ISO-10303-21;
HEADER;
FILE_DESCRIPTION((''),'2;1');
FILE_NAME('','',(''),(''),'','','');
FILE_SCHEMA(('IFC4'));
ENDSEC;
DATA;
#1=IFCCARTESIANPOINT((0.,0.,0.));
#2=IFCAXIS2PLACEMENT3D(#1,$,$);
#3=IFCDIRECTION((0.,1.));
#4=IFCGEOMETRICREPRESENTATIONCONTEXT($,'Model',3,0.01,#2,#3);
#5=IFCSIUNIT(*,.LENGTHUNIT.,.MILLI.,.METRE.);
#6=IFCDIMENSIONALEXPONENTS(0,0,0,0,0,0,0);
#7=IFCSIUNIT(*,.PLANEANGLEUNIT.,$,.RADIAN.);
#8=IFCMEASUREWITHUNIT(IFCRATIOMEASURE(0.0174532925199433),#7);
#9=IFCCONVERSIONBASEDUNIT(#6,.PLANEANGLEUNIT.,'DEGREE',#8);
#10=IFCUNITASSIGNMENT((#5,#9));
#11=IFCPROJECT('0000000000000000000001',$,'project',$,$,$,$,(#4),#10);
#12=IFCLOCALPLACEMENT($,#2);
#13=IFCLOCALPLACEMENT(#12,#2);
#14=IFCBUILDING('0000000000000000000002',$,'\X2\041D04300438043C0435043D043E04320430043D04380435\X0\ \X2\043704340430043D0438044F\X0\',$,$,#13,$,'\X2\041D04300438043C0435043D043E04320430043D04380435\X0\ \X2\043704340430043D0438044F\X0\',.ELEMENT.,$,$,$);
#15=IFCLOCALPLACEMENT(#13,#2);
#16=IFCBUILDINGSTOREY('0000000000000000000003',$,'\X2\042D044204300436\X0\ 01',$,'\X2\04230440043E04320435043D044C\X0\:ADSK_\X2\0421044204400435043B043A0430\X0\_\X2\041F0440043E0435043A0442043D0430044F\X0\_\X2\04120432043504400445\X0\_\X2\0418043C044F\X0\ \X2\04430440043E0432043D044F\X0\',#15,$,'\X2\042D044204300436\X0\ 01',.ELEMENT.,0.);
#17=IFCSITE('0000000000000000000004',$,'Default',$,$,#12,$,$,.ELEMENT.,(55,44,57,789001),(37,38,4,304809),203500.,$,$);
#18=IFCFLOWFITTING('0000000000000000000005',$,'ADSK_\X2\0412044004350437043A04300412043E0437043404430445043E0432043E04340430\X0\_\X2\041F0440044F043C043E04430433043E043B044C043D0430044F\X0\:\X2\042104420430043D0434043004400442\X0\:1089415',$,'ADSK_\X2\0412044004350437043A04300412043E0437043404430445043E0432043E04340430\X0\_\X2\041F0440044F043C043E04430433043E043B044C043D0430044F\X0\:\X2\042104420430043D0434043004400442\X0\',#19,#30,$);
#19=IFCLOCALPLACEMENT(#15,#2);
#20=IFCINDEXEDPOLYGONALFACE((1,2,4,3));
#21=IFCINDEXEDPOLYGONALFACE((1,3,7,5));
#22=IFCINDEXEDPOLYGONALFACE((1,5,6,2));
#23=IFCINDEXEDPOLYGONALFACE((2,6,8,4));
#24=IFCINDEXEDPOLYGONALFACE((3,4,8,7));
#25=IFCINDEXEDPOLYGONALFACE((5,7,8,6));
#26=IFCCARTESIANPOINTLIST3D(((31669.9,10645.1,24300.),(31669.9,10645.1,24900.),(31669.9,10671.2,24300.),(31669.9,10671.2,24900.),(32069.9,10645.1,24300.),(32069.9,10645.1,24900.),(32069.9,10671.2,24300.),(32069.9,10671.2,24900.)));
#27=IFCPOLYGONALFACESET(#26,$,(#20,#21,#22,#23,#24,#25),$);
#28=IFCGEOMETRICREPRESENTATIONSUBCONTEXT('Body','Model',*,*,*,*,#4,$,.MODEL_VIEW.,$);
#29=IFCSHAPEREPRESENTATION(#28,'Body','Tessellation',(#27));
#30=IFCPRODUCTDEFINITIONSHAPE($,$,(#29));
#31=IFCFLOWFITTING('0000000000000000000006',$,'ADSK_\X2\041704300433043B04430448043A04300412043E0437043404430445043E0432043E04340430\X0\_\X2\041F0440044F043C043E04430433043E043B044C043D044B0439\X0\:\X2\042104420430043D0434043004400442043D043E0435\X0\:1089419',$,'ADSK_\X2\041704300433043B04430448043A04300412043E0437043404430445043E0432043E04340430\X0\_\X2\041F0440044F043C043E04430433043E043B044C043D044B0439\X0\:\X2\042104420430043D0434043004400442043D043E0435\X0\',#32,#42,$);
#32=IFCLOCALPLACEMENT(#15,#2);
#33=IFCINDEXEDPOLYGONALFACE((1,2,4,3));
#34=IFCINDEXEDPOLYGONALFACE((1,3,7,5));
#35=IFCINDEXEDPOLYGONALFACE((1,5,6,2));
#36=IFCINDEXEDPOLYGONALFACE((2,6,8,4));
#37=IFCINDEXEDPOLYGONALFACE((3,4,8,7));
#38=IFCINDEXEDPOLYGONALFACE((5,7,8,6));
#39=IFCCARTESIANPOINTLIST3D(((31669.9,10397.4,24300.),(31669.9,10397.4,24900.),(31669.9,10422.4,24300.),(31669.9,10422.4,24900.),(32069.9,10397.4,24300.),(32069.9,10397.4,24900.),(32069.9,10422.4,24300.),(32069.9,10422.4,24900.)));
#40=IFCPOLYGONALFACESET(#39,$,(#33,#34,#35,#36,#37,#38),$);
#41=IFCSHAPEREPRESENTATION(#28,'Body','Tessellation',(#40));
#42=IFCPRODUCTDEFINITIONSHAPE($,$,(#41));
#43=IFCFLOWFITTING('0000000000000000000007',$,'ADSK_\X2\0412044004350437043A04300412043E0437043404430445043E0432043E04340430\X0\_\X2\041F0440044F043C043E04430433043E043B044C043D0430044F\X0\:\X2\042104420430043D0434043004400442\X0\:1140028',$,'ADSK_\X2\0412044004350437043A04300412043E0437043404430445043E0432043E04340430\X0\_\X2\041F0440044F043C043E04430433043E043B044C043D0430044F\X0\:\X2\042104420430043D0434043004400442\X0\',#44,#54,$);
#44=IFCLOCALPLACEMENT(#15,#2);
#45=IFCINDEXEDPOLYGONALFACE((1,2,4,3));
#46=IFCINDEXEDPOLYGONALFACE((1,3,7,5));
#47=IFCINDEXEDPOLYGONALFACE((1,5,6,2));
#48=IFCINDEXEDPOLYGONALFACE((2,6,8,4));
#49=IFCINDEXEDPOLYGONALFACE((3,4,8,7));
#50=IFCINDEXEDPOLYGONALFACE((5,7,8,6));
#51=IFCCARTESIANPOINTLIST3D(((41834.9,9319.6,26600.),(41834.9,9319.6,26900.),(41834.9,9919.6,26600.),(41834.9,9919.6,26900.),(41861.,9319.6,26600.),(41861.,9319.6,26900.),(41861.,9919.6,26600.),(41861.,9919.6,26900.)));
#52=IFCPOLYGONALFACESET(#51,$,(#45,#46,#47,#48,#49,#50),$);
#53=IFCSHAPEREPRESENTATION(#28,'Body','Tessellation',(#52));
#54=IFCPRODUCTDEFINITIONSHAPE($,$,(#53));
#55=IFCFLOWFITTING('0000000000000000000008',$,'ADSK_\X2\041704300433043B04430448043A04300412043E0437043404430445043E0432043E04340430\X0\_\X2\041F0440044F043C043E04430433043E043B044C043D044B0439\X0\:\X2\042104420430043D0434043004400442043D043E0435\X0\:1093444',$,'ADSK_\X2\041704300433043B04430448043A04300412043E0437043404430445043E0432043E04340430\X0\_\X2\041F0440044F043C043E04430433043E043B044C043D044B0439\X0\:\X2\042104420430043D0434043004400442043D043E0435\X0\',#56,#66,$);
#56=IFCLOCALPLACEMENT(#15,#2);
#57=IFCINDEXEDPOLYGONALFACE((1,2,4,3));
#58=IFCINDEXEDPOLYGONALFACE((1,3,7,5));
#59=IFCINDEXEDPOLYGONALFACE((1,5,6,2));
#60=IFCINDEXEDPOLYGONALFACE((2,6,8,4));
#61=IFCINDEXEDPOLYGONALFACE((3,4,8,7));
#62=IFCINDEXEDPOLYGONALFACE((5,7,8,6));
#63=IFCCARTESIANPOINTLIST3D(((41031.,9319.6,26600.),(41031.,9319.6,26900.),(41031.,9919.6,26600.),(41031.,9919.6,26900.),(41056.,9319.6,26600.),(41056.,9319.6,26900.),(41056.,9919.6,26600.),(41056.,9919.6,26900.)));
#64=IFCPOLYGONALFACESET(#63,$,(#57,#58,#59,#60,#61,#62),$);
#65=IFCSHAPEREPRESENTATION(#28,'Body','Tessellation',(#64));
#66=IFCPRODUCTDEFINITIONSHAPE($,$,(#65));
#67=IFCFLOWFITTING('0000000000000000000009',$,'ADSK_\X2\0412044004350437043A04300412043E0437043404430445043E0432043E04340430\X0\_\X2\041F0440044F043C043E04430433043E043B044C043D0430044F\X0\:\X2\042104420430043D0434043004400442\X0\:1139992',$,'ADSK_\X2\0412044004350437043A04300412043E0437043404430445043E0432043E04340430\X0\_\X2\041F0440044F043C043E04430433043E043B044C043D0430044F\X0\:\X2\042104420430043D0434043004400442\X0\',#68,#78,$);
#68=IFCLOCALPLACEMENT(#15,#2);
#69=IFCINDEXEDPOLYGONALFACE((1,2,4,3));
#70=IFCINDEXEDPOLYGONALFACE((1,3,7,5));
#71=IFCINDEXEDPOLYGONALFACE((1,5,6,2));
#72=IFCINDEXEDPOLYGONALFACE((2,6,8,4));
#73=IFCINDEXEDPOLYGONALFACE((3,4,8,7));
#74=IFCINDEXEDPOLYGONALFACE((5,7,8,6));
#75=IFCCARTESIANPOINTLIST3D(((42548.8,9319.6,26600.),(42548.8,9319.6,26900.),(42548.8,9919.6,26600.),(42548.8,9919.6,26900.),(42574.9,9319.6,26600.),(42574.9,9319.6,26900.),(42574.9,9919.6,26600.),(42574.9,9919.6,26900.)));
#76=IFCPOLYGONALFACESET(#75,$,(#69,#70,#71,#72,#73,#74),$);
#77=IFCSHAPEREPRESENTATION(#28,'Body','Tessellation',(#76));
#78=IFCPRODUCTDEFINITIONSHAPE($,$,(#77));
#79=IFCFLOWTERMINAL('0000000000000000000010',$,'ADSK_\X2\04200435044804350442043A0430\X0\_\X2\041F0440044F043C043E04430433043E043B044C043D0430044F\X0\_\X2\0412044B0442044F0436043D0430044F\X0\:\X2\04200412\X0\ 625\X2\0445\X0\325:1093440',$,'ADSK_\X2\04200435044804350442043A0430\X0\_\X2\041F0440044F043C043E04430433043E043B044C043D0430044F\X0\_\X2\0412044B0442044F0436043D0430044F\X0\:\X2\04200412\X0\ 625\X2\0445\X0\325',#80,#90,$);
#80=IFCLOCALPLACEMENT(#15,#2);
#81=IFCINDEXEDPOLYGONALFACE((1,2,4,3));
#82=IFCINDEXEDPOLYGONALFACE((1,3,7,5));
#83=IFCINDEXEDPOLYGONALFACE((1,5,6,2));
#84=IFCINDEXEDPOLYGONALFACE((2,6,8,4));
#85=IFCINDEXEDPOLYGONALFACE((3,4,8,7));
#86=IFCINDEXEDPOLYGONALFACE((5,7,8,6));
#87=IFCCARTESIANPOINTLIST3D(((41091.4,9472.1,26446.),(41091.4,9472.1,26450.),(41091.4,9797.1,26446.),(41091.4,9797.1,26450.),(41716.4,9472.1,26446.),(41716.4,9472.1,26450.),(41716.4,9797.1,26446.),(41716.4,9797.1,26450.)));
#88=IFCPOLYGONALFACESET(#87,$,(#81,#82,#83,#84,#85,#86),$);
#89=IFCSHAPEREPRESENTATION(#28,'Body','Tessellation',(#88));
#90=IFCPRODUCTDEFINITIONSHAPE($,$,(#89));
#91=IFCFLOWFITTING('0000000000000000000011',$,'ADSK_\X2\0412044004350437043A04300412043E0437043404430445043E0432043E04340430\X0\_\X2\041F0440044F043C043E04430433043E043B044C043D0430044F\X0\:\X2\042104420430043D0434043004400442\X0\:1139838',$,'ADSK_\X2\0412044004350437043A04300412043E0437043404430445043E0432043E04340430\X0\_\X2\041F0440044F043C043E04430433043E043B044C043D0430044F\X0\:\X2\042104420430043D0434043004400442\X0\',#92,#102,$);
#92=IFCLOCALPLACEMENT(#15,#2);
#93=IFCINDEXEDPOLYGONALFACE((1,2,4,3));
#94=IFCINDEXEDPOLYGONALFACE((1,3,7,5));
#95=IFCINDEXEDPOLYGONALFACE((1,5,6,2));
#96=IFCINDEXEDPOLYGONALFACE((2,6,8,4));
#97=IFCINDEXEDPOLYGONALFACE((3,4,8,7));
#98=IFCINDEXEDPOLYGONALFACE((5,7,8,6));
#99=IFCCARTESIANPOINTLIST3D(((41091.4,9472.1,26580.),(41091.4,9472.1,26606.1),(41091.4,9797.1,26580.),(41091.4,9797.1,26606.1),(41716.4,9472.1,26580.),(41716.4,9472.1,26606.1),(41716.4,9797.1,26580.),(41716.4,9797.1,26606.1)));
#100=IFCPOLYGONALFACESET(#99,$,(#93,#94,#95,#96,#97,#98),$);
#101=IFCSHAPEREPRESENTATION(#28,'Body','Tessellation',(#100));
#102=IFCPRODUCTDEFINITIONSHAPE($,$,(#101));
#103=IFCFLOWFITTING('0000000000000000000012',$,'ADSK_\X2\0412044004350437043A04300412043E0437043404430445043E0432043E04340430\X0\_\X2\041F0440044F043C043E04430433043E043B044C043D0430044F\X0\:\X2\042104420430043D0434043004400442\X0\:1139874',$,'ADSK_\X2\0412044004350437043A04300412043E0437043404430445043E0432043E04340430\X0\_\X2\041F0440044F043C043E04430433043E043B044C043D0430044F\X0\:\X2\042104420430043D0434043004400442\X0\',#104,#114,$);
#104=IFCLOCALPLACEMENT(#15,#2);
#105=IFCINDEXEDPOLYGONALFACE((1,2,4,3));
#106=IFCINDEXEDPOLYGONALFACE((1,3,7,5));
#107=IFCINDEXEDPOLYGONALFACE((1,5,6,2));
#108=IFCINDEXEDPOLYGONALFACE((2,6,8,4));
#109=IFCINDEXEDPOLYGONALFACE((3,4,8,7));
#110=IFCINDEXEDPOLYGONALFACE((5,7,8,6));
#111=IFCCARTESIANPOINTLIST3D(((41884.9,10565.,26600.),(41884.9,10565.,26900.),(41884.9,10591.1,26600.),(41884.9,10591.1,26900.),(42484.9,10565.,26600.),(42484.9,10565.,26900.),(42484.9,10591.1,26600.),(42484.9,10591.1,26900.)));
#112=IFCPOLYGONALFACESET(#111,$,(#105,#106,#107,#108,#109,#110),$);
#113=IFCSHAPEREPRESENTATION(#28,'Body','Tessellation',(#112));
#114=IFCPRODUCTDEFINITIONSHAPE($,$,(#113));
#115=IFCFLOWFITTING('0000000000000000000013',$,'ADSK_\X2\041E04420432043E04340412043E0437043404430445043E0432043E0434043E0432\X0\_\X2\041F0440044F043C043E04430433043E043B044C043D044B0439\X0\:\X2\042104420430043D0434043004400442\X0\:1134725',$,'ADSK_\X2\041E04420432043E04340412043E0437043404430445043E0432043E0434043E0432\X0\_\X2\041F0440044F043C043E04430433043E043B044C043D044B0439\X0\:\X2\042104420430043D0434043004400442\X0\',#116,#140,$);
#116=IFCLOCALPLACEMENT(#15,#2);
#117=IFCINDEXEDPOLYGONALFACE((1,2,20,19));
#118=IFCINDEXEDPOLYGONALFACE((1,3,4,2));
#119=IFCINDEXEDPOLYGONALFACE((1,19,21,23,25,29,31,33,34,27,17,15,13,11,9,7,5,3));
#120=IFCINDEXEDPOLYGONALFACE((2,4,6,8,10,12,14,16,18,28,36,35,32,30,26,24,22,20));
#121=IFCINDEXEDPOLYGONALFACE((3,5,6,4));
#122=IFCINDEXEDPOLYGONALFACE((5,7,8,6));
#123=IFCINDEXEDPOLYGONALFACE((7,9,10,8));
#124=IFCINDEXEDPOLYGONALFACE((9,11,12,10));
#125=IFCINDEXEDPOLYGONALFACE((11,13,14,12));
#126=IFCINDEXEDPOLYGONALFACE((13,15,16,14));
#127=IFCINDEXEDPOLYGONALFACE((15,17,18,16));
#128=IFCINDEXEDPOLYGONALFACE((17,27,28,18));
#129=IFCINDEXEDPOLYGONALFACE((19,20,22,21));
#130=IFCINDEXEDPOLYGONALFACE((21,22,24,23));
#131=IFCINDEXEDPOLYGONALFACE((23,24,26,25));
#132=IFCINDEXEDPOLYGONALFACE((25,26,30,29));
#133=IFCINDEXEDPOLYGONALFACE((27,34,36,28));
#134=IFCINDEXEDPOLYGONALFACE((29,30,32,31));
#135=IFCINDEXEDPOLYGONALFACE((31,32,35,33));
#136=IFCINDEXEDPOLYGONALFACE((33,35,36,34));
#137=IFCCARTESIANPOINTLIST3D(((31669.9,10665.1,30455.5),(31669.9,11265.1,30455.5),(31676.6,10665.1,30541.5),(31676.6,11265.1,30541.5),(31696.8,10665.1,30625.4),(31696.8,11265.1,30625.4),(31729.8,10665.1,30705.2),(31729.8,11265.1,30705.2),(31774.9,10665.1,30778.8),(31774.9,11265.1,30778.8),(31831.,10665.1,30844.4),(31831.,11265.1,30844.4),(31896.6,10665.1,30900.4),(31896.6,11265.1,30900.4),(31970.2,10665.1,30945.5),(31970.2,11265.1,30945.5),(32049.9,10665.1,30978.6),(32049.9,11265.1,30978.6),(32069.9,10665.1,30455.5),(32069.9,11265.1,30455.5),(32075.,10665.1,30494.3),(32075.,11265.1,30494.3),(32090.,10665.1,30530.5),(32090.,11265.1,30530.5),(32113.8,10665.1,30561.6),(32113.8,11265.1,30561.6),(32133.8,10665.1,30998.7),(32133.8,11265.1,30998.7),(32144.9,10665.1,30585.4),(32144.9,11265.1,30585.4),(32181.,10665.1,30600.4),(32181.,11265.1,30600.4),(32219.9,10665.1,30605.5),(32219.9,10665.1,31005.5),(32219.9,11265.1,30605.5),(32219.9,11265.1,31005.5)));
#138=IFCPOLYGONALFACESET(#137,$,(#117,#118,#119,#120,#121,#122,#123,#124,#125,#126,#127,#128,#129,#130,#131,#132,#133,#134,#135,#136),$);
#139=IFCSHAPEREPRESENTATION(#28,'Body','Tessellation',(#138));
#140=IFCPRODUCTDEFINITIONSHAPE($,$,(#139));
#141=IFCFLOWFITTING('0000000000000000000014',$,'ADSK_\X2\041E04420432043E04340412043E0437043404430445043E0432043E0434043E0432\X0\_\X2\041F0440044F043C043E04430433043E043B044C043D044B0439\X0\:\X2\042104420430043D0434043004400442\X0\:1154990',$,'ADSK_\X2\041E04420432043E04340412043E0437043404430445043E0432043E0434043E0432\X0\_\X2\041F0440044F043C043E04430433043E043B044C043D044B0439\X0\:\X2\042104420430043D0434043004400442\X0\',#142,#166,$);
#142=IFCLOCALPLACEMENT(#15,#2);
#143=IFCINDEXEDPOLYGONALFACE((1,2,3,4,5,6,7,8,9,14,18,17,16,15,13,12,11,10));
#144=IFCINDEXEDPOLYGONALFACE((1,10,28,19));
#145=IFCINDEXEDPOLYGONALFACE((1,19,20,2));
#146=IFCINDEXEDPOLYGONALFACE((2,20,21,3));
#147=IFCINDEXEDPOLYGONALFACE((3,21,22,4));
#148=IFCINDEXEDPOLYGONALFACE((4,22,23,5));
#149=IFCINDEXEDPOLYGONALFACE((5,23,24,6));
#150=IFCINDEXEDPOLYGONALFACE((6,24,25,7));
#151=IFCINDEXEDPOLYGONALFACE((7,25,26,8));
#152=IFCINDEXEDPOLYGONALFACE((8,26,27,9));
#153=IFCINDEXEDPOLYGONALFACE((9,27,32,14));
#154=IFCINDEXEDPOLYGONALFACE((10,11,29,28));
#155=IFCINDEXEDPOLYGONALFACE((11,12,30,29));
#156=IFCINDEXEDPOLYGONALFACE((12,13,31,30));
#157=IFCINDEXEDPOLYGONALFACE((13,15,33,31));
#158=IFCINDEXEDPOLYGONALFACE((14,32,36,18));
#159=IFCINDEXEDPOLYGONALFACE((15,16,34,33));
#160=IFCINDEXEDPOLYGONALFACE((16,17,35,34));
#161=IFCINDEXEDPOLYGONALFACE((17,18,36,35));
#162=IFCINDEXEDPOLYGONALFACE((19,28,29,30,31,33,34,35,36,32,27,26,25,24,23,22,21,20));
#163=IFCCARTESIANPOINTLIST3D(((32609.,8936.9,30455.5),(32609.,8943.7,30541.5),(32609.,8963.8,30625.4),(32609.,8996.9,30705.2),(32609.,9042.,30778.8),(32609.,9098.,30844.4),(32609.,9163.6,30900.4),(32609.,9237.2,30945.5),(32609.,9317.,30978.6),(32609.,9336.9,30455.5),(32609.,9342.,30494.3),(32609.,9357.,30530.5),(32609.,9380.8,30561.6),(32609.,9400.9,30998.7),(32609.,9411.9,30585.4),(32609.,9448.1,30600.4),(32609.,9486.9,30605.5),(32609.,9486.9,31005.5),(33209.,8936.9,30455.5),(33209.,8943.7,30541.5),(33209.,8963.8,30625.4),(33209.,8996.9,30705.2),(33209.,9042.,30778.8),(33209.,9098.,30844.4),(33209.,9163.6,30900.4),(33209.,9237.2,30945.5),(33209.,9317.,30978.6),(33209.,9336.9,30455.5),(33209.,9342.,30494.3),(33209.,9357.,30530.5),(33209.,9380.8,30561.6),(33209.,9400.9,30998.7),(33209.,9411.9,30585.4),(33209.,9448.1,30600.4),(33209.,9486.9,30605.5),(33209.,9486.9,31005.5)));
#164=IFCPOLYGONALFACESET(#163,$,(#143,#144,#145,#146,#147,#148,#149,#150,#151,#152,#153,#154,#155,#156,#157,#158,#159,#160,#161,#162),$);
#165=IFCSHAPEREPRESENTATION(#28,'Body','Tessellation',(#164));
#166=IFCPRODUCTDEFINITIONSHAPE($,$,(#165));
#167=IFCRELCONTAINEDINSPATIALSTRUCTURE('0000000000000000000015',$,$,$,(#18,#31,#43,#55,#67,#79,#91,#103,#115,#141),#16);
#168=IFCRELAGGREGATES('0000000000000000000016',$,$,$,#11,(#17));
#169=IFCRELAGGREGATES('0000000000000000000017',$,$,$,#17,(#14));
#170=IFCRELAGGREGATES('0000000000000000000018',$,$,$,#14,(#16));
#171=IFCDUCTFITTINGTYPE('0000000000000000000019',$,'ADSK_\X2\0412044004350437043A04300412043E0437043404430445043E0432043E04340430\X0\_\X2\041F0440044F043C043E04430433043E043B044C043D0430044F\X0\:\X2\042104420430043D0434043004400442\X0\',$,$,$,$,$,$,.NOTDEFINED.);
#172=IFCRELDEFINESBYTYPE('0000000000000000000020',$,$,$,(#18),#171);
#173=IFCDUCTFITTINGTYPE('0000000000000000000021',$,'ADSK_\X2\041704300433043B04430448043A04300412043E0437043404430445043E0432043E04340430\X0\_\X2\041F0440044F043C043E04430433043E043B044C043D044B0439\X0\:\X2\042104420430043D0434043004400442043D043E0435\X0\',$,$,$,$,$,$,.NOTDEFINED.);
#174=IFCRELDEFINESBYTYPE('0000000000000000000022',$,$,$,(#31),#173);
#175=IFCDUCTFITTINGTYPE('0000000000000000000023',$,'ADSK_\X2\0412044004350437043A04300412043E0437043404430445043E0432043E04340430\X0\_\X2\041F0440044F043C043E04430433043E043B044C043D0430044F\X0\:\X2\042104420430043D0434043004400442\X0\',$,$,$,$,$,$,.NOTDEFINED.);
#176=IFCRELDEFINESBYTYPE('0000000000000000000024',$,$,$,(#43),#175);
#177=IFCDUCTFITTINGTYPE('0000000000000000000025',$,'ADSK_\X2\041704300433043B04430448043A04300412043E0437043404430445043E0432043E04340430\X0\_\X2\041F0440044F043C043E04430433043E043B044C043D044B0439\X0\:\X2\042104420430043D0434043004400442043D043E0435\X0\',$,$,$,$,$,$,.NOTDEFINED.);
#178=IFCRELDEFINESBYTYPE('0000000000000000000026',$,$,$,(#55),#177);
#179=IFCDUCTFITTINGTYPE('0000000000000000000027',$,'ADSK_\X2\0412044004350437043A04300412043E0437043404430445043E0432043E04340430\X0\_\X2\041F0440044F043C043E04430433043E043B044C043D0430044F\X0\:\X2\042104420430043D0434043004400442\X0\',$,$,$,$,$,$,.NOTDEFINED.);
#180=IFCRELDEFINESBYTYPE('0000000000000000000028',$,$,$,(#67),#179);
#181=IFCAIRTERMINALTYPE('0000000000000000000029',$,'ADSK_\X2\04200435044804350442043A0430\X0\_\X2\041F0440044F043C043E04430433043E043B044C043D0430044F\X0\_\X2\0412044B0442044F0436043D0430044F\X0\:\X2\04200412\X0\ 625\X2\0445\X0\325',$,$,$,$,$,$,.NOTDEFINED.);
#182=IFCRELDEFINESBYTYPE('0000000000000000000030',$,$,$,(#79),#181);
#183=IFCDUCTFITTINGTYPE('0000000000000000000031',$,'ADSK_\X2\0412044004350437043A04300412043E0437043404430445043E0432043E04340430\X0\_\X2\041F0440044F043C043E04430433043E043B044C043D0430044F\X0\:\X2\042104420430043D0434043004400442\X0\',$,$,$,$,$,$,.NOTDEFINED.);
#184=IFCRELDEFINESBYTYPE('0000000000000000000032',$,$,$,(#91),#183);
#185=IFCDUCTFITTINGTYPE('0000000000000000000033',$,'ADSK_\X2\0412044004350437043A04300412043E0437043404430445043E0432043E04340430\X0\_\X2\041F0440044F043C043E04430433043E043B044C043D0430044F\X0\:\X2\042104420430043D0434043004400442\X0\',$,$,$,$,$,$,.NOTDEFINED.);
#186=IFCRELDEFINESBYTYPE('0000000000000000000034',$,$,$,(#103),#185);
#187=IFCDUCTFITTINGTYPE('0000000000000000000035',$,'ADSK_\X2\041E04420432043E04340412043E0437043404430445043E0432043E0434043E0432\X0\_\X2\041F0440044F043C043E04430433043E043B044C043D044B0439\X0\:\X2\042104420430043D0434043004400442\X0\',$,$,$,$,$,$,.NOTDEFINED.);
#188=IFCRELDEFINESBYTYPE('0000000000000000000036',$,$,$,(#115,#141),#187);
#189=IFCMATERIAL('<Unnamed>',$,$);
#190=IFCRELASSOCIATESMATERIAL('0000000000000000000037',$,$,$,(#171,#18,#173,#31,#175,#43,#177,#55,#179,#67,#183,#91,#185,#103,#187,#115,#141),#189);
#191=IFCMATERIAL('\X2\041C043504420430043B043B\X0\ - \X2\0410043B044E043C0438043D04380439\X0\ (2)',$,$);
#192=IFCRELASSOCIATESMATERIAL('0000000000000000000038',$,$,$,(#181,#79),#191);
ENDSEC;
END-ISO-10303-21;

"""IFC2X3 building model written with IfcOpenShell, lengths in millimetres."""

from ifc_helpers import new_model, entity, si_unit, converted_unit, direction, frame, frame_2d, origin, origin_2d_with_axis, place, context, subcontext, project, spatial, polyline, circle_curve, parameter, trimmed, segment, composite_curve, rectangle, outline, extrude, source, transform, mapped, material, type_object, type_shapes, element, save


model = new_model("IFC2X3")

# Units and contexts
model_context = context("Model", 3, precision=0.01, world=origin(), true_north=direction((0.0, 1.0)))
body_context = subcontext(model_context, "Body", "Model", "MODEL_VIEW")
ifc_project = project(units=[si_unit("LENGTHUNIT", "METRE", prefix="MILLI"), converted_unit("PLANEANGLEUNIT", "DEGREE", entity("IfcRatioMeasure", 0.0174532925199433), si_unit("PLANEANGLEUNIT", "RADIAN"), dimensions=[0, 0, 0, 0, 0, 0, 0])], contexts=[model_context])

# Site, building, storey
site_placement = place(None, origin())
site = spatial("IfcSite", under=ifc_project, at=site_placement, Name="Default", CompositionType="ELEMENT", RefLatitude=(55, 44, 57, 789001), RefLongitude=(37, 38, 4, 304809), RefElevation=203500.0)
building_placement = place(site_placement, origin())
building = spatial("IfcBuilding", under=site, at=building_placement, Name="Наименование здания", LongName="Наименование здания", CompositionType="ELEMENT")
storey_placement = place(building_placement, origin())
storey = spatial("IfcBuildingStorey", under=building, at=storey_placement, Name="Этаж 01", ObjectType="Уровень:ADSK_Стрелка_Проектная_Вверх_Имя уровня", LongName="Этаж 01", CompositionType="ELEMENT", Elevation=0.0)

# Flow fittings
ifc_material_1 = material(Name="<Unnamed>")
duct_fitting_type_1 = type_object("IfcDuctFittingType", Name="ADSK_ВрезкаВоздуховода_Прямоугольная:Стандарт", PredefinedType="NOTDEFINED", material=ifc_material_1)
shared_shape_1 = source(origin(), body_context, "Body", "SweptSolid", [
    extrude(rectangle(XDim=26.1, YDim=600.0, at=origin_2d_with_axis()), frame((7.0, 0.0, -200.0)), (0.0, 0.0, 1.0), 400.0),
])
type_shapes(duct_fitting_type_1, [shared_shape_1])
flow_fitting_1_placement = place(storey_placement, frame((31869.9, 10665.1, 24600.0), z_axis=(-1.0, 0.0, 0.0), x_axis=(0.0, -1.0, 0.0)))
element("IfcFlowFitting", 1, at=flow_fitting_1_placement, inside=storey, type_object=duct_fitting_type_1, material=ifc_material_1, Name="ADSK_ВрезкаВоздуховода_Прямоугольная:Стандарт:1089415", ObjectType="ADSK_ВрезкаВоздуховода_Прямоугольная:Стандарт", context=body_context, shape_type="MappedRepresentation", body=[
    mapped(shared_shape_1, transform((0.0, 0.0, 0.0), scale=1.0)),
])
duct_fitting_type_2 = type_object("IfcDuctFittingType", Name="ADSK_ЗаглушкаВоздуховода_Прямоугольный:Стандартное", PredefinedType="NOTDEFINED", material=ifc_material_1)
shared_shape_2 = source(origin(), body_context, "Body", "SweptSolid", [
    extrude(rectangle(XDim=25.0, YDim=400.0, at=origin_2d_with_axis()), frame((12.5, 0.0, -300.0)), (0.0, 0.0, 1.0), 600.0),
])
type_shapes(duct_fitting_type_2, [shared_shape_2])
flow_fitting_2_placement = place(storey_placement, frame((31869.9, 10422.4, 24600.0), z_axis=(0.0, 0.0, 1.0), x_axis=(0.0, -1.0, 0.0)))
element("IfcFlowFitting", 2, at=flow_fitting_2_placement, inside=storey, type_object=duct_fitting_type_2, material=ifc_material_1, Name="ADSK_ЗаглушкаВоздуховода_Прямоугольный:Стандартное:1089419", ObjectType="ADSK_ЗаглушкаВоздуховода_Прямоугольный:Стандартное", context=body_context, shape_type="MappedRepresentation", body=[
    mapped(shared_shape_2, transform((0.0, 0.0, 0.0), scale=1.0)),
])
duct_fitting_type_3 = type_object("IfcDuctFittingType", Name="ADSK_ВрезкаВоздуховода_Прямоугольная:Стандарт", PredefinedType="NOTDEFINED", material=ifc_material_1)
shared_shape_3 = source(origin(), body_context, "Body", "SweptSolid", [
    extrude(rectangle(XDim=26.1, YDim=600.0, at=origin_2d_with_axis()), frame((7.0, 0.0, -150.0)), (0.0, 0.0, 1.0), 300.0),
])
type_shapes(duct_fitting_type_3, [shared_shape_3])
flow_fitting_3_placement = place(storey_placement, frame((41854.9, 9619.6, 26750.0), z_axis=(0.0, 0.0, -1.0), x_axis=(-1.0, 0.0, 0.0)))
element("IfcFlowFitting", 3, at=flow_fitting_3_placement, inside=storey, type_object=duct_fitting_type_3, material=ifc_material_1, Name="ADSK_ВрезкаВоздуховода_Прямоугольная:Стандарт:1140028", ObjectType="ADSK_ВрезкаВоздуховода_Прямоугольная:Стандарт", context=body_context, shape_type="MappedRepresentation", body=[
    mapped(shared_shape_3, transform((0.0, 0.0, 0.0), scale=1.0)),
])
duct_fitting_type_4 = type_object("IfcDuctFittingType", Name="ADSK_ЗаглушкаВоздуховода_Прямоугольный:Стандартное", PredefinedType="NOTDEFINED", material=ifc_material_1)
shared_shape_4 = source(origin(), body_context, "Body", "SweptSolid", [
    extrude(rectangle(XDim=25.0, YDim=600.0, at=origin_2d_with_axis()), frame((12.5, 0.0, -150.0)), (0.0, 0.0, 1.0), 300.0),
])
type_shapes(duct_fitting_type_4, [shared_shape_4])
flow_fitting_4_placement = place(storey_placement, frame((41056.0, 9619.6, 26750.0), z_axis=(0.0, 0.0, 1.0), x_axis=(-1.0, 0.0, 0.0)))
element("IfcFlowFitting", 4, at=flow_fitting_4_placement, inside=storey, type_object=duct_fitting_type_4, material=ifc_material_1, Name="ADSK_ЗаглушкаВоздуховода_Прямоугольный:Стандартное:1093444", ObjectType="ADSK_ЗаглушкаВоздуховода_Прямоугольный:Стандартное", context=body_context, shape_type="MappedRepresentation", body=[
    mapped(shared_shape_4, transform((0.0, 0.0, 0.0), scale=1.0)),
])
duct_fitting_type_5 = type_object("IfcDuctFittingType", Name="ADSK_ВрезкаВоздуховода_Прямоугольная:Стандарт", PredefinedType="NOTDEFINED", material=ifc_material_1)
shared_shape_5 = source(origin(), body_context, "Body", "SweptSolid", [
    extrude(rectangle(XDim=600.0, YDim=26.1, at=origin_2d_with_axis()), frame((7.0, 0.0, -150.0), z_axis=(0.0, 0.0, 1.0), x_axis=(0.0, -1.0, 0.0)), (0.0, 0.0, 1.0), 300.0),
])
type_shapes(duct_fitting_type_5, [shared_shape_5])
flow_fitting_5_placement = place(storey_placement, frame((42554.9, 9619.6, 26750.0), z_axis=(0.0, 0.0, -1.0), x_axis=(1.0, 0.0, 0.0)))
element("IfcFlowFitting", 5, at=flow_fitting_5_placement, inside=storey, type_object=duct_fitting_type_5, material=ifc_material_1, Name="ADSK_ВрезкаВоздуховода_Прямоугольная:Стандарт:1139992", ObjectType="ADSK_ВрезкаВоздуховода_Прямоугольная:Стандарт", context=body_context, shape_type="MappedRepresentation", body=[
    mapped(shared_shape_5, transform((0.0, 0.0, 0.0), scale=1.0)),
])

# Flow terminal
ifc_material_2 = material(Name="Металл - Алюминий (2)")
air_terminal_type = type_object("IfcAirTerminalType", Name="ADSK_Решетка_Прямоугольная_Вытяжная:РВ 625х325", PredefinedType="NOTDEFINED", material=ifc_material_2)
shared_shape_6 = source(origin(), body_context, "Body", "SweptSolid", [
    extrude(rectangle(XDim=4.0, YDim=625.0, at=origin_2d_with_axis()), frame((0.0, -2.0, -162.5), z_axis=(0.0, 0.0, 1.0), x_axis=(0.0, 1.0, 0.0)), (0.0, 0.0, 1.0), 325.0),
])
type_shapes(air_terminal_type, [shared_shape_6])
flow_terminal_placement = place(storey_placement, frame((41403.9, 9634.6, 26450.0), z_axis=(0.0, -1.0, 0.0), x_axis=(1.0, 0.0, 0.0)))
element("IfcFlowTerminal", 6, at=flow_terminal_placement, inside=storey, type_object=air_terminal_type, material=ifc_material_2, Name="ADSK_Решетка_Прямоугольная_Вытяжная:РВ 625х325:1093440", ObjectType="ADSK_Решетка_Прямоугольная_Вытяжная:РВ 625х325", context=body_context, shape_type="MappedRepresentation", body=[
    mapped(shared_shape_6, transform((0.0, 0.0, 0.0), scale=1.0)),
])

# Flow fittings
duct_fitting_type_6 = type_object("IfcDuctFittingType", Name="ADSK_ВрезкаВоздуховода_Прямоугольная:Стандарт", PredefinedType="NOTDEFINED", material=ifc_material_1)
shared_shape_7 = source(origin(), body_context, "Body", "SweptSolid", [
    extrude(rectangle(XDim=625.0, YDim=26.1, at=origin_2d_with_axis()), frame((7.0, 0.0, -162.5), z_axis=(0.0, 0.0, 1.0), x_axis=(0.0, -1.0, 0.0)), (0.0, 0.0, 1.0), 325.0),
])
type_shapes(duct_fitting_type_6, [shared_shape_7])
flow_fitting_6_placement = place(storey_placement, frame((41403.9, 9634.6, 26600.0), z_axis=(0.0, 1.0, 0.0), x_axis=(0.0, 0.0, -1.0)))
element("IfcFlowFitting", 7, at=flow_fitting_6_placement, inside=storey, type_object=duct_fitting_type_6, material=ifc_material_1, Name="ADSK_ВрезкаВоздуховода_Прямоугольная:Стандарт:1139838", ObjectType="ADSK_ВрезкаВоздуховода_Прямоугольная:Стандарт", context=body_context, shape_type="MappedRepresentation", body=[
    mapped(shared_shape_7, transform((0.0, 0.0, 0.0), scale=1.0)),
])
duct_fitting_type_7 = type_object("IfcDuctFittingType", Name="ADSK_ВрезкаВоздуховода_Прямоугольная:Стандарт", PredefinedType="NOTDEFINED", material=ifc_material_1)
shared_shape_8 = source(origin(), body_context, "Body", "SweptSolid", [
    extrude(rectangle(XDim=26.1, YDim=300.0, at=origin_2d_with_axis()), frame((7.0, 0.0, -300.0)), (0.0, 0.0, 1.0), 600.0),
])
type_shapes(duct_fitting_type_7, [shared_shape_8])
flow_fitting_7_placement = place(storey_placement, frame((42184.9, 10585.0, 26750.0), z_axis=(-1.0, 0.0, 0.0), x_axis=(0.0, -1.0, 0.0)))
element("IfcFlowFitting", 8, at=flow_fitting_7_placement, inside=storey, type_object=duct_fitting_type_7, material=ifc_material_1, Name="ADSK_ВрезкаВоздуховода_Прямоугольная:Стандарт:1139874", ObjectType="ADSK_ВрезкаВоздуховода_Прямоугольная:Стандарт", context=body_context, shape_type="MappedRepresentation", body=[
    mapped(shared_shape_8, transform((0.0, 0.0, 0.0), scale=1.0)),
])
duct_fitting_type_8 = type_object("IfcDuctFittingType", Name="ADSK_ОтводВоздуховодов_Прямоугольный:Стандарт", PredefinedType="NOTDEFINED", material=ifc_material_1)
shared_shape_9 = source(origin(), body_context, "Body", "SweptSolid", [
    extrude(outline(composite_curve([segment(polyline([(-375.0, -175.0), (25.0, -175.0)]), True, "CONTINUOUS"), segment(trimmed(circle_curve(frame_2d((175.0, -175.0), x_axis=(0.0, 1.0)), 150.0), [parameter(0.0)], [parameter(90.0)], True, "PARAMETER"), False, "CONTINUOUS"), segment(polyline([(175.0, -25.0), (175.0, 375.0)]), True, "CONTINUOUS"), segment(trimmed(circle_curve(frame_2d((175.0, -175.0), x_axis=(0.0, 1.0)), 550.0), [parameter(0.0)], [parameter(90.0)], True, "PARAMETER"), True, "CONTINUOUS")], self_intersect=False)), frame((-175.0, 175.0, -300.0), z_axis=(0.0, 0.0, 1.0), x_axis=(-1.0, 0.0, 0.0)), (0.0, 0.0, 1.0), 600.0),
])
type_shapes(duct_fitting_type_8, [shared_shape_9])
for number, where, z_axis, x_axis, name in (
    (9, (31869.9, 10965.1, 30805.5), (0.0, -1.0, 0.0), (-1.0, 0.0, 0.0), "ADSK_ОтводВоздуховодов_Прямоугольный:Стандарт:1134725"),
    (10, (32909.0, 9136.9, 30805.5), (1.0, 0.0, 0.0), (0.0, -1.0, 0.0), "ADSK_ОтводВоздуховодов_Прямоугольный:Стандарт:1154990"),
):
    element("IfcFlowFitting", number, at=place(storey_placement, frame(where, z_axis=z_axis, x_axis=x_axis)), inside=storey, type_object=duct_fitting_type_8, material=ifc_material_1, Name=name, ObjectType="ADSK_ОтводВоздуховодов_Прямоугольный:Стандарт", context=body_context, shape_type="MappedRepresentation", body=[
        mapped(shared_shape_9, transform((0.0, 0.0, 0.0), scale=1.0)),
    ])

save(model, "model.ifc")
